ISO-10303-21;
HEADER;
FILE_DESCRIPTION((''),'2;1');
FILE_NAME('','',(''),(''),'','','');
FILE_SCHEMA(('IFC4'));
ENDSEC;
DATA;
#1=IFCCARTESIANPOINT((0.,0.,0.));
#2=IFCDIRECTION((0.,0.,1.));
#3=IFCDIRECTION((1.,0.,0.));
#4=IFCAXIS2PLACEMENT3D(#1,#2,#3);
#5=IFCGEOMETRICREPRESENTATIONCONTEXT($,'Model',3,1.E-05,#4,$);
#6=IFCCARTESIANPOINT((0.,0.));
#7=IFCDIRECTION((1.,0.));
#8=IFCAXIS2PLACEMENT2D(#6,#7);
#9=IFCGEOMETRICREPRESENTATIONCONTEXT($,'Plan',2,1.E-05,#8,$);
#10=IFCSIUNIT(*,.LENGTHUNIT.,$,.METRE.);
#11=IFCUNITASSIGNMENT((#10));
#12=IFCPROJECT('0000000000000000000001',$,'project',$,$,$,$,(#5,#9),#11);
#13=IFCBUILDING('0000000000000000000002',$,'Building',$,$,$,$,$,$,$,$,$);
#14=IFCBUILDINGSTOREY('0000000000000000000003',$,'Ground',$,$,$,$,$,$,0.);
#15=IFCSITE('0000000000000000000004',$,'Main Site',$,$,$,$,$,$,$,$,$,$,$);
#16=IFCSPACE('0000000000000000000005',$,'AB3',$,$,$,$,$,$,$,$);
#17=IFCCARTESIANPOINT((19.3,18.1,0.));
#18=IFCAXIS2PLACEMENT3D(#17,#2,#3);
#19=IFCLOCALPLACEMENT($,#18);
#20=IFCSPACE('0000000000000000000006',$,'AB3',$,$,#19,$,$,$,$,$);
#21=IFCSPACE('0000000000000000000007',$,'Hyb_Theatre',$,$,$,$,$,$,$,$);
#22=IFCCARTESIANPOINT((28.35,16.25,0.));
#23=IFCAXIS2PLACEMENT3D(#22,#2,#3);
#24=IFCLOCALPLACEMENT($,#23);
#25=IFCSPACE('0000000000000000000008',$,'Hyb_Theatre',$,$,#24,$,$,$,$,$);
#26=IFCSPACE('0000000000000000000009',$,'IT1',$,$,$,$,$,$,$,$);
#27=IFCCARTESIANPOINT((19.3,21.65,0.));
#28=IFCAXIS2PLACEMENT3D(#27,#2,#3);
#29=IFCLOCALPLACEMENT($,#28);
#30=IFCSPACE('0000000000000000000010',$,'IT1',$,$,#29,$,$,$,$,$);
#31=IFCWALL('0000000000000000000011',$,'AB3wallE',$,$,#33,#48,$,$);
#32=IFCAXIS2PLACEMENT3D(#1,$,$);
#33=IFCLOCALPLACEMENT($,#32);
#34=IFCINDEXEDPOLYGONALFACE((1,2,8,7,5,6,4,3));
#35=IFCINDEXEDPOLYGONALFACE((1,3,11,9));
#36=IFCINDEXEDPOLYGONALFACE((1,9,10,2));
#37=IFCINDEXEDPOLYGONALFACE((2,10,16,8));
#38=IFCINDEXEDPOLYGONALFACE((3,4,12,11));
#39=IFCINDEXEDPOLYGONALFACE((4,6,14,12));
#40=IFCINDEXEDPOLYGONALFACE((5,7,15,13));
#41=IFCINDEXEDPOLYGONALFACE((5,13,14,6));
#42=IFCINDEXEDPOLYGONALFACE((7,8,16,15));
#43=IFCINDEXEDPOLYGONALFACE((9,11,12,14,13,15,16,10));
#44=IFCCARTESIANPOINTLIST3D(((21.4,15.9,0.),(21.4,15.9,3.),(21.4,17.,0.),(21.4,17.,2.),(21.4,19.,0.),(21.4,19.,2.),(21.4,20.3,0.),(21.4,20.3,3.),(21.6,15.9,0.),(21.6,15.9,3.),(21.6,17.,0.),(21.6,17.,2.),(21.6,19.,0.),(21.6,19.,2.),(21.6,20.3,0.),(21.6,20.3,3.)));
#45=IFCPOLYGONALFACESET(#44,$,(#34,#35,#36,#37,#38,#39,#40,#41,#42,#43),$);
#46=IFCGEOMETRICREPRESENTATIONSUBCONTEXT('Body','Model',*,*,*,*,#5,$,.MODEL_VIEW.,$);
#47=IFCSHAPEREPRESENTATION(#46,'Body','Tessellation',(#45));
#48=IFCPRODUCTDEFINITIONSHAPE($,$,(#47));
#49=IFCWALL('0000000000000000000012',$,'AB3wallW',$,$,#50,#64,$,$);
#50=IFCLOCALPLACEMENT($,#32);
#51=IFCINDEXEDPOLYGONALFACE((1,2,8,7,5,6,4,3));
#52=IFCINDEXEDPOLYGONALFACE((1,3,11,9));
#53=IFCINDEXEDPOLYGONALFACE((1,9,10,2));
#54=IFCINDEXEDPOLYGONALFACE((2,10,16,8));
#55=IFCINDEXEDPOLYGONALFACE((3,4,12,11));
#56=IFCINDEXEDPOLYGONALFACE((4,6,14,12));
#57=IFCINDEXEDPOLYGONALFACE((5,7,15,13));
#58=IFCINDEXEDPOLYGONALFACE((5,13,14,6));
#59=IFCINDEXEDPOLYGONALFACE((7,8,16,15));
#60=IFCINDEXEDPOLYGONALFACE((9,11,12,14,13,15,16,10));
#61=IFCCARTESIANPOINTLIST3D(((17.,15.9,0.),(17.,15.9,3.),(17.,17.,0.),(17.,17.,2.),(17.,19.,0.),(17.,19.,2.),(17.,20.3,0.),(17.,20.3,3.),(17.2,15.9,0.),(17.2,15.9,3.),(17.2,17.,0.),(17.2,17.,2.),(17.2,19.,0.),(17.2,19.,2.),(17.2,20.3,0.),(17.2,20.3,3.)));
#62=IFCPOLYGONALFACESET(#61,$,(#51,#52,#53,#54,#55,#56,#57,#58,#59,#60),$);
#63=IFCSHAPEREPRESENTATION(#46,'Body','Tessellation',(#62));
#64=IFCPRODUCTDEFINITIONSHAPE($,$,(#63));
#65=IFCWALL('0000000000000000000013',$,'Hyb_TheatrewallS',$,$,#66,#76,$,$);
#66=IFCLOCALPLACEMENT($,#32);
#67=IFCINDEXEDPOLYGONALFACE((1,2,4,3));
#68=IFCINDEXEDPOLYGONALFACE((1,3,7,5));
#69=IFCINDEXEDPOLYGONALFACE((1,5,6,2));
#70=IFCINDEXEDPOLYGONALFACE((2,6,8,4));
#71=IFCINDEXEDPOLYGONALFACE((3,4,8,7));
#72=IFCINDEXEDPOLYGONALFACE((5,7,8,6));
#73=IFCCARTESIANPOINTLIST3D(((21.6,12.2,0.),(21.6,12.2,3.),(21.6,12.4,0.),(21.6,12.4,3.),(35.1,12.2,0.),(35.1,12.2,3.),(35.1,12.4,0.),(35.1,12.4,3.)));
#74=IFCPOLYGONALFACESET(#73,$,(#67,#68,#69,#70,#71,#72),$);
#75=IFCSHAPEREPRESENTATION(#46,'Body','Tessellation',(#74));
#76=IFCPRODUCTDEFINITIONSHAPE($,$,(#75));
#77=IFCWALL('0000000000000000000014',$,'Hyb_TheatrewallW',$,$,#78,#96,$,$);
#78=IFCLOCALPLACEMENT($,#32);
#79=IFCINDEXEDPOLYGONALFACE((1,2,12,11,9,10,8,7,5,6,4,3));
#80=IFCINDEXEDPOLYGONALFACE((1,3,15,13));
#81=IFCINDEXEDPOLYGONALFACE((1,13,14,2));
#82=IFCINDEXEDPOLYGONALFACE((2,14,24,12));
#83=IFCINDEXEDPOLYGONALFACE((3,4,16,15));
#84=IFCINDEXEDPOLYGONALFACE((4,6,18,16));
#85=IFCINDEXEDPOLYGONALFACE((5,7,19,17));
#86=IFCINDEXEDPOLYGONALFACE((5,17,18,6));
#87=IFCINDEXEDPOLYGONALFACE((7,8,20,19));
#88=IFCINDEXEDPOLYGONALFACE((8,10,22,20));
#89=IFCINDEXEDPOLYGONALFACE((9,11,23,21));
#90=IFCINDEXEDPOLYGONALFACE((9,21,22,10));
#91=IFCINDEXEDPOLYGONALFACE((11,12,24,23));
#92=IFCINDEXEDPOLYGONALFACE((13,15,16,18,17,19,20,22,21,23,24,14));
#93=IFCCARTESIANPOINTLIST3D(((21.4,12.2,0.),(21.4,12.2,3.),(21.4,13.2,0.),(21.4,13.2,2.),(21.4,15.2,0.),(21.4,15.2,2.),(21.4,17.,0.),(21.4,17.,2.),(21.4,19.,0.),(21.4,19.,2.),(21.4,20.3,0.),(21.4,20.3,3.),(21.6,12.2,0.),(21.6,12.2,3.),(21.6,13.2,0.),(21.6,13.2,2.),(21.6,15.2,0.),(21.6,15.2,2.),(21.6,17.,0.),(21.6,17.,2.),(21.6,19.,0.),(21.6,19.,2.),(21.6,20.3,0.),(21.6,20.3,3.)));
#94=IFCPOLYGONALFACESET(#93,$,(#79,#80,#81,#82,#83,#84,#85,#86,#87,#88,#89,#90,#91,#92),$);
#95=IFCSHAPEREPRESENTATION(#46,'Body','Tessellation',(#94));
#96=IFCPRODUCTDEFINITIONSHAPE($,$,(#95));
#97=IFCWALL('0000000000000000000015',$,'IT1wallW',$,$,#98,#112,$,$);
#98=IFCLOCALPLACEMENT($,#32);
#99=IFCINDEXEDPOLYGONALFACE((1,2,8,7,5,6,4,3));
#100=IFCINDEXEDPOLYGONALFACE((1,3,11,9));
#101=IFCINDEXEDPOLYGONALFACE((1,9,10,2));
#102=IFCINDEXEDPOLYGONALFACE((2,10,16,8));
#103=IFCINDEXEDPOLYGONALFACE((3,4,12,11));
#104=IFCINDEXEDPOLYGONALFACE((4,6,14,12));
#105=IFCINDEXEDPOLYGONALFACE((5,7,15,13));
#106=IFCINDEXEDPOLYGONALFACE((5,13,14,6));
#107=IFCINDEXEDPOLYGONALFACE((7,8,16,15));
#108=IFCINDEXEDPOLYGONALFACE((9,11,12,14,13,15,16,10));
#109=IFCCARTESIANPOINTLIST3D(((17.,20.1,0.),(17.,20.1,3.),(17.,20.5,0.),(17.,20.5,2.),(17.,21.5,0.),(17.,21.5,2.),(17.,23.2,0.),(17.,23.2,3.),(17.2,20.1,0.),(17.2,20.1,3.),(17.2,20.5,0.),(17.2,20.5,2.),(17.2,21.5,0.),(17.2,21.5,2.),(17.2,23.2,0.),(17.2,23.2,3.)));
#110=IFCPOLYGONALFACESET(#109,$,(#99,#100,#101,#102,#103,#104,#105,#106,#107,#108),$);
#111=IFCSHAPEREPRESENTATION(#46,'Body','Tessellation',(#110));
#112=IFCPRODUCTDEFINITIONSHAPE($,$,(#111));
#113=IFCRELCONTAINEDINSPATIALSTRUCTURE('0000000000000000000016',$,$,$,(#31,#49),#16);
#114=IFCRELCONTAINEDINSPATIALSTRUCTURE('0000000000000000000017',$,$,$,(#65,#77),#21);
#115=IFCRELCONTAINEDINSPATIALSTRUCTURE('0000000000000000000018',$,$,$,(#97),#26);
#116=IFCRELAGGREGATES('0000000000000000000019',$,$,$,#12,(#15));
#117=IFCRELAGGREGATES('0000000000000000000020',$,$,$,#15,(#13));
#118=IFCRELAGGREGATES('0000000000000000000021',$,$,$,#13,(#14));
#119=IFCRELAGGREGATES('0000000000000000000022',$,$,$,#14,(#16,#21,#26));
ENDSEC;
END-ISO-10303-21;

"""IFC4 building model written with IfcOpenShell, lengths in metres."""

from ifc_helpers import new_model, si_unit, frame, origin_with_axes, origin_2d_with_axis, place, context, subcontext, project, spatial, indexed_curve, outline, extrude, element, save


model = new_model("IFC4")

# Units and contexts
model_context = context("Model", 3, precision=1e-05, world=origin_with_axes())
plan_context = context("Plan", 2, precision=1e-05, world=origin_2d_with_axis())
body_context = subcontext(model_context, "Body", "Model", "MODEL_VIEW")
ifc_project = project(units=[si_unit("LENGTHUNIT", "METRE")], contexts=[model_context, plan_context])

# Site, building, storey
site = spatial("IfcSite", under=ifc_project, Name="Main Site")
building = spatial("IfcBuilding", under=site, Name="Building")
storey = spatial("IfcBuildingStorey", under=building, Name="Ground", Elevation=0.0)

# Shared definitions
space_1 = spatial("IfcSpace", under=storey, Name="AB3")

# Wall
wall_1_placement = place(None, frame((21.6, 15.9, 0.0), z_axis=(0.0, 0.0, 1.0), x_axis=(0.0, 1.0, 0.0)))
wall_1 = element("IfcWall", 1, at=wall_1_placement, inside=space_1, Name="AB3wallE", context=body_context, shape_type="SweptSolid", body=[
    extrude(outline(indexed_curve([(0.0, 0.0), (0.0, 0.2), (4.4, 0.2), (4.4, 0.0), (0.0, 0.0)], self_intersect=False)), origin_with_axes(), (0.0, 0.0, 1.0), 3.0),
])

# Shared definitions
space_2_placement = place(None, frame((19.3, 18.1, 0.0), z_axis=(0.0, 0.0, 1.0), x_axis=(1.0, 0.0, 0.0)))
space_2 = spatial("IfcSpace", at=space_2_placement, Name="AB3")

# Opening
opening_1_placement = place(wall_1_placement, frame((1.1, 0.0, 0.0), z_axis=(0.0, 0.0, 1.0), x_axis=(1.0, 0.0, 0.0)))
element("IfcOpeningElement", 2, at=opening_1_placement, inside=space_2, cuts=wall_1, context=body_context, shape_type="SweptSolid", body=[
    extrude(outline(indexed_curve([(0.0, 0.0), (0.0, 0.4), (2.0, 0.4), (2.0, 0.0), (0.0, 0.0)], self_intersect=False)), origin_with_axes(), (0.0, 0.0, 1.0), 2.0),
])

# Wall, opening
wall_2_placement = place(None, frame((17.2, 15.9, 0.0), z_axis=(0.0, 0.0, 1.0), x_axis=(0.0, 1.0, 0.0)))
wall_2 = element("IfcWall", 3, at=wall_2_placement, inside=space_1, Name="AB3wallW", context=body_context, shape_type="SweptSolid", body=[
    extrude(outline(indexed_curve([(0.0, 0.0), (0.0, 0.2), (4.4, 0.2), (4.4, 0.0), (0.0, 0.0)], self_intersect=False)), origin_with_axes(), (0.0, 0.0, 1.0), 3.0),
])
opening_2_placement = place(wall_2_placement, frame((1.1, 0.0, 0.0), z_axis=(0.0, 0.0, 1.0), x_axis=(1.0, 0.0, 0.0)))
element("IfcOpeningElement", 4, at=opening_2_placement, inside=space_2, cuts=wall_2, context=body_context, shape_type="SweptSolid", body=[
    extrude(outline(indexed_curve([(0.0, 0.0), (0.0, 0.4), (2.0, 0.4), (2.0, 0.0), (0.0, 0.0)], self_intersect=False)), origin_with_axes(), (0.0, 0.0, 1.0), 2.0),
])

# Shared definitions
space_3 = spatial("IfcSpace", under=storey, Name="Hyb_Theatre")

# Walls
wall_3_placement = place(None, frame((21.6, 12.2, 0.0), z_axis=(0.0, 0.0, 1.0), x_axis=(1.0, 0.0, 0.0)))
element("IfcWall", 5, at=wall_3_placement, inside=space_3, Name="Hyb_TheatrewallS", context=body_context, shape_type="SweptSolid", body=[
    extrude(outline(indexed_curve([(0.0, 0.0), (0.0, 0.2), (13.5, 0.2), (13.5, 0.0), (0.0, 0.0)], self_intersect=False)), origin_with_axes(), (0.0, 0.0, 1.0), 3.0),
])
wall_4_placement = place(None, frame((21.6, 12.2, 0.0), z_axis=(0.0, 0.0, 1.0), x_axis=(0.0, 1.0, 0.0)))
wall_4 = element("IfcWall", 6, at=wall_4_placement, inside=space_3, Name="Hyb_TheatrewallW", context=body_context, shape_type="SweptSolid", body=[
    extrude(outline(indexed_curve([(0.0, 0.0), (0.0, 0.2), (8.1, 0.2), (8.1, 0.0), (0.0, 0.0)], self_intersect=False)), origin_with_axes(), (0.0, 0.0, 1.0), 3.0),
])

# Shared definitions
space_4_placement = place(None, frame((28.35, 16.25, 0.0), z_axis=(0.0, 0.0, 1.0), x_axis=(1.0, 0.0, 0.0)))
space_4 = spatial("IfcSpace", at=space_4_placement, Name="Hyb_Theatre")

# Openings
opening_3_placement = place(wall_4_placement, frame((1.0, 0.0, 0.0), z_axis=(0.0, 0.0, 1.0), x_axis=(1.0, 0.0, 0.0)))
element("IfcOpeningElement", 7, at=opening_3_placement, inside=space_4, cuts=wall_4, context=body_context, shape_type="SweptSolid", body=[
    extrude(outline(indexed_curve([(0.0, 0.0), (0.0, 0.4), (2.0, 0.4), (2.0, 0.0), (0.0, 0.0)], self_intersect=False)), origin_with_axes(), (0.0, 0.0, 1.0), 2.0),
])
opening_4_placement = place(wall_4_placement, frame((4.8, 0.0, 0.0), z_axis=(0.0, 0.0, 1.0), x_axis=(1.0, 0.0, 0.0)))
element("IfcOpeningElement", 8, at=opening_4_placement, inside=space_4, cuts=wall_4, context=body_context, shape_type="SweptSolid", body=[
    extrude(outline(indexed_curve([(0.0, 0.0), (0.0, 0.4), (2.0, 0.4), (2.0, 0.0), (0.0, 0.0)], self_intersect=False)), origin_with_axes(), (0.0, 0.0, 1.0), 2.0),
])

# Shared definitions
space_5 = spatial("IfcSpace", under=storey, Name="IT1")

# Wall
wall_5_placement = place(None, frame((17.2, 20.1, 0.0), z_axis=(0.0, 0.0, 1.0), x_axis=(0.0, 1.0, 0.0)))
wall_5 = element("IfcWall", 9, at=wall_5_placement, inside=space_5, Name="IT1wallW", context=body_context, shape_type="SweptSolid", body=[
    extrude(outline(indexed_curve([(0.0, 0.0), (0.0, 0.2), (3.1, 0.2), (3.1, 0.0), (0.0, 0.0)], self_intersect=False)), origin_with_axes(), (0.0, 0.0, 1.0), 3.0),
])

# Shared definitions
space_6_placement = place(None, frame((19.3, 21.65, 0.0), z_axis=(0.0, 0.0, 1.0), x_axis=(1.0, 0.0, 0.0)))
space_6 = spatial("IfcSpace", at=space_6_placement, Name="IT1")

# Opening
opening_5_placement = place(wall_5_placement, frame((0.4, 0.0, 0.0), z_axis=(0.0, 0.0, 1.0), x_axis=(1.0, 0.0, 0.0)))
element("IfcOpeningElement", 10, at=opening_5_placement, inside=space_6, cuts=wall_5, context=body_context, shape_type="SweptSolid", body=[
    extrude(outline(indexed_curve([(0.0, 0.0), (0.0, 0.4), (1.0, 0.4), (1.0, 0.0), (0.0, 0.0)], self_intersect=False)), origin_with_axes(), (0.0, 0.0, 1.0), 2.0),
])

save(model, "model.ifc")
